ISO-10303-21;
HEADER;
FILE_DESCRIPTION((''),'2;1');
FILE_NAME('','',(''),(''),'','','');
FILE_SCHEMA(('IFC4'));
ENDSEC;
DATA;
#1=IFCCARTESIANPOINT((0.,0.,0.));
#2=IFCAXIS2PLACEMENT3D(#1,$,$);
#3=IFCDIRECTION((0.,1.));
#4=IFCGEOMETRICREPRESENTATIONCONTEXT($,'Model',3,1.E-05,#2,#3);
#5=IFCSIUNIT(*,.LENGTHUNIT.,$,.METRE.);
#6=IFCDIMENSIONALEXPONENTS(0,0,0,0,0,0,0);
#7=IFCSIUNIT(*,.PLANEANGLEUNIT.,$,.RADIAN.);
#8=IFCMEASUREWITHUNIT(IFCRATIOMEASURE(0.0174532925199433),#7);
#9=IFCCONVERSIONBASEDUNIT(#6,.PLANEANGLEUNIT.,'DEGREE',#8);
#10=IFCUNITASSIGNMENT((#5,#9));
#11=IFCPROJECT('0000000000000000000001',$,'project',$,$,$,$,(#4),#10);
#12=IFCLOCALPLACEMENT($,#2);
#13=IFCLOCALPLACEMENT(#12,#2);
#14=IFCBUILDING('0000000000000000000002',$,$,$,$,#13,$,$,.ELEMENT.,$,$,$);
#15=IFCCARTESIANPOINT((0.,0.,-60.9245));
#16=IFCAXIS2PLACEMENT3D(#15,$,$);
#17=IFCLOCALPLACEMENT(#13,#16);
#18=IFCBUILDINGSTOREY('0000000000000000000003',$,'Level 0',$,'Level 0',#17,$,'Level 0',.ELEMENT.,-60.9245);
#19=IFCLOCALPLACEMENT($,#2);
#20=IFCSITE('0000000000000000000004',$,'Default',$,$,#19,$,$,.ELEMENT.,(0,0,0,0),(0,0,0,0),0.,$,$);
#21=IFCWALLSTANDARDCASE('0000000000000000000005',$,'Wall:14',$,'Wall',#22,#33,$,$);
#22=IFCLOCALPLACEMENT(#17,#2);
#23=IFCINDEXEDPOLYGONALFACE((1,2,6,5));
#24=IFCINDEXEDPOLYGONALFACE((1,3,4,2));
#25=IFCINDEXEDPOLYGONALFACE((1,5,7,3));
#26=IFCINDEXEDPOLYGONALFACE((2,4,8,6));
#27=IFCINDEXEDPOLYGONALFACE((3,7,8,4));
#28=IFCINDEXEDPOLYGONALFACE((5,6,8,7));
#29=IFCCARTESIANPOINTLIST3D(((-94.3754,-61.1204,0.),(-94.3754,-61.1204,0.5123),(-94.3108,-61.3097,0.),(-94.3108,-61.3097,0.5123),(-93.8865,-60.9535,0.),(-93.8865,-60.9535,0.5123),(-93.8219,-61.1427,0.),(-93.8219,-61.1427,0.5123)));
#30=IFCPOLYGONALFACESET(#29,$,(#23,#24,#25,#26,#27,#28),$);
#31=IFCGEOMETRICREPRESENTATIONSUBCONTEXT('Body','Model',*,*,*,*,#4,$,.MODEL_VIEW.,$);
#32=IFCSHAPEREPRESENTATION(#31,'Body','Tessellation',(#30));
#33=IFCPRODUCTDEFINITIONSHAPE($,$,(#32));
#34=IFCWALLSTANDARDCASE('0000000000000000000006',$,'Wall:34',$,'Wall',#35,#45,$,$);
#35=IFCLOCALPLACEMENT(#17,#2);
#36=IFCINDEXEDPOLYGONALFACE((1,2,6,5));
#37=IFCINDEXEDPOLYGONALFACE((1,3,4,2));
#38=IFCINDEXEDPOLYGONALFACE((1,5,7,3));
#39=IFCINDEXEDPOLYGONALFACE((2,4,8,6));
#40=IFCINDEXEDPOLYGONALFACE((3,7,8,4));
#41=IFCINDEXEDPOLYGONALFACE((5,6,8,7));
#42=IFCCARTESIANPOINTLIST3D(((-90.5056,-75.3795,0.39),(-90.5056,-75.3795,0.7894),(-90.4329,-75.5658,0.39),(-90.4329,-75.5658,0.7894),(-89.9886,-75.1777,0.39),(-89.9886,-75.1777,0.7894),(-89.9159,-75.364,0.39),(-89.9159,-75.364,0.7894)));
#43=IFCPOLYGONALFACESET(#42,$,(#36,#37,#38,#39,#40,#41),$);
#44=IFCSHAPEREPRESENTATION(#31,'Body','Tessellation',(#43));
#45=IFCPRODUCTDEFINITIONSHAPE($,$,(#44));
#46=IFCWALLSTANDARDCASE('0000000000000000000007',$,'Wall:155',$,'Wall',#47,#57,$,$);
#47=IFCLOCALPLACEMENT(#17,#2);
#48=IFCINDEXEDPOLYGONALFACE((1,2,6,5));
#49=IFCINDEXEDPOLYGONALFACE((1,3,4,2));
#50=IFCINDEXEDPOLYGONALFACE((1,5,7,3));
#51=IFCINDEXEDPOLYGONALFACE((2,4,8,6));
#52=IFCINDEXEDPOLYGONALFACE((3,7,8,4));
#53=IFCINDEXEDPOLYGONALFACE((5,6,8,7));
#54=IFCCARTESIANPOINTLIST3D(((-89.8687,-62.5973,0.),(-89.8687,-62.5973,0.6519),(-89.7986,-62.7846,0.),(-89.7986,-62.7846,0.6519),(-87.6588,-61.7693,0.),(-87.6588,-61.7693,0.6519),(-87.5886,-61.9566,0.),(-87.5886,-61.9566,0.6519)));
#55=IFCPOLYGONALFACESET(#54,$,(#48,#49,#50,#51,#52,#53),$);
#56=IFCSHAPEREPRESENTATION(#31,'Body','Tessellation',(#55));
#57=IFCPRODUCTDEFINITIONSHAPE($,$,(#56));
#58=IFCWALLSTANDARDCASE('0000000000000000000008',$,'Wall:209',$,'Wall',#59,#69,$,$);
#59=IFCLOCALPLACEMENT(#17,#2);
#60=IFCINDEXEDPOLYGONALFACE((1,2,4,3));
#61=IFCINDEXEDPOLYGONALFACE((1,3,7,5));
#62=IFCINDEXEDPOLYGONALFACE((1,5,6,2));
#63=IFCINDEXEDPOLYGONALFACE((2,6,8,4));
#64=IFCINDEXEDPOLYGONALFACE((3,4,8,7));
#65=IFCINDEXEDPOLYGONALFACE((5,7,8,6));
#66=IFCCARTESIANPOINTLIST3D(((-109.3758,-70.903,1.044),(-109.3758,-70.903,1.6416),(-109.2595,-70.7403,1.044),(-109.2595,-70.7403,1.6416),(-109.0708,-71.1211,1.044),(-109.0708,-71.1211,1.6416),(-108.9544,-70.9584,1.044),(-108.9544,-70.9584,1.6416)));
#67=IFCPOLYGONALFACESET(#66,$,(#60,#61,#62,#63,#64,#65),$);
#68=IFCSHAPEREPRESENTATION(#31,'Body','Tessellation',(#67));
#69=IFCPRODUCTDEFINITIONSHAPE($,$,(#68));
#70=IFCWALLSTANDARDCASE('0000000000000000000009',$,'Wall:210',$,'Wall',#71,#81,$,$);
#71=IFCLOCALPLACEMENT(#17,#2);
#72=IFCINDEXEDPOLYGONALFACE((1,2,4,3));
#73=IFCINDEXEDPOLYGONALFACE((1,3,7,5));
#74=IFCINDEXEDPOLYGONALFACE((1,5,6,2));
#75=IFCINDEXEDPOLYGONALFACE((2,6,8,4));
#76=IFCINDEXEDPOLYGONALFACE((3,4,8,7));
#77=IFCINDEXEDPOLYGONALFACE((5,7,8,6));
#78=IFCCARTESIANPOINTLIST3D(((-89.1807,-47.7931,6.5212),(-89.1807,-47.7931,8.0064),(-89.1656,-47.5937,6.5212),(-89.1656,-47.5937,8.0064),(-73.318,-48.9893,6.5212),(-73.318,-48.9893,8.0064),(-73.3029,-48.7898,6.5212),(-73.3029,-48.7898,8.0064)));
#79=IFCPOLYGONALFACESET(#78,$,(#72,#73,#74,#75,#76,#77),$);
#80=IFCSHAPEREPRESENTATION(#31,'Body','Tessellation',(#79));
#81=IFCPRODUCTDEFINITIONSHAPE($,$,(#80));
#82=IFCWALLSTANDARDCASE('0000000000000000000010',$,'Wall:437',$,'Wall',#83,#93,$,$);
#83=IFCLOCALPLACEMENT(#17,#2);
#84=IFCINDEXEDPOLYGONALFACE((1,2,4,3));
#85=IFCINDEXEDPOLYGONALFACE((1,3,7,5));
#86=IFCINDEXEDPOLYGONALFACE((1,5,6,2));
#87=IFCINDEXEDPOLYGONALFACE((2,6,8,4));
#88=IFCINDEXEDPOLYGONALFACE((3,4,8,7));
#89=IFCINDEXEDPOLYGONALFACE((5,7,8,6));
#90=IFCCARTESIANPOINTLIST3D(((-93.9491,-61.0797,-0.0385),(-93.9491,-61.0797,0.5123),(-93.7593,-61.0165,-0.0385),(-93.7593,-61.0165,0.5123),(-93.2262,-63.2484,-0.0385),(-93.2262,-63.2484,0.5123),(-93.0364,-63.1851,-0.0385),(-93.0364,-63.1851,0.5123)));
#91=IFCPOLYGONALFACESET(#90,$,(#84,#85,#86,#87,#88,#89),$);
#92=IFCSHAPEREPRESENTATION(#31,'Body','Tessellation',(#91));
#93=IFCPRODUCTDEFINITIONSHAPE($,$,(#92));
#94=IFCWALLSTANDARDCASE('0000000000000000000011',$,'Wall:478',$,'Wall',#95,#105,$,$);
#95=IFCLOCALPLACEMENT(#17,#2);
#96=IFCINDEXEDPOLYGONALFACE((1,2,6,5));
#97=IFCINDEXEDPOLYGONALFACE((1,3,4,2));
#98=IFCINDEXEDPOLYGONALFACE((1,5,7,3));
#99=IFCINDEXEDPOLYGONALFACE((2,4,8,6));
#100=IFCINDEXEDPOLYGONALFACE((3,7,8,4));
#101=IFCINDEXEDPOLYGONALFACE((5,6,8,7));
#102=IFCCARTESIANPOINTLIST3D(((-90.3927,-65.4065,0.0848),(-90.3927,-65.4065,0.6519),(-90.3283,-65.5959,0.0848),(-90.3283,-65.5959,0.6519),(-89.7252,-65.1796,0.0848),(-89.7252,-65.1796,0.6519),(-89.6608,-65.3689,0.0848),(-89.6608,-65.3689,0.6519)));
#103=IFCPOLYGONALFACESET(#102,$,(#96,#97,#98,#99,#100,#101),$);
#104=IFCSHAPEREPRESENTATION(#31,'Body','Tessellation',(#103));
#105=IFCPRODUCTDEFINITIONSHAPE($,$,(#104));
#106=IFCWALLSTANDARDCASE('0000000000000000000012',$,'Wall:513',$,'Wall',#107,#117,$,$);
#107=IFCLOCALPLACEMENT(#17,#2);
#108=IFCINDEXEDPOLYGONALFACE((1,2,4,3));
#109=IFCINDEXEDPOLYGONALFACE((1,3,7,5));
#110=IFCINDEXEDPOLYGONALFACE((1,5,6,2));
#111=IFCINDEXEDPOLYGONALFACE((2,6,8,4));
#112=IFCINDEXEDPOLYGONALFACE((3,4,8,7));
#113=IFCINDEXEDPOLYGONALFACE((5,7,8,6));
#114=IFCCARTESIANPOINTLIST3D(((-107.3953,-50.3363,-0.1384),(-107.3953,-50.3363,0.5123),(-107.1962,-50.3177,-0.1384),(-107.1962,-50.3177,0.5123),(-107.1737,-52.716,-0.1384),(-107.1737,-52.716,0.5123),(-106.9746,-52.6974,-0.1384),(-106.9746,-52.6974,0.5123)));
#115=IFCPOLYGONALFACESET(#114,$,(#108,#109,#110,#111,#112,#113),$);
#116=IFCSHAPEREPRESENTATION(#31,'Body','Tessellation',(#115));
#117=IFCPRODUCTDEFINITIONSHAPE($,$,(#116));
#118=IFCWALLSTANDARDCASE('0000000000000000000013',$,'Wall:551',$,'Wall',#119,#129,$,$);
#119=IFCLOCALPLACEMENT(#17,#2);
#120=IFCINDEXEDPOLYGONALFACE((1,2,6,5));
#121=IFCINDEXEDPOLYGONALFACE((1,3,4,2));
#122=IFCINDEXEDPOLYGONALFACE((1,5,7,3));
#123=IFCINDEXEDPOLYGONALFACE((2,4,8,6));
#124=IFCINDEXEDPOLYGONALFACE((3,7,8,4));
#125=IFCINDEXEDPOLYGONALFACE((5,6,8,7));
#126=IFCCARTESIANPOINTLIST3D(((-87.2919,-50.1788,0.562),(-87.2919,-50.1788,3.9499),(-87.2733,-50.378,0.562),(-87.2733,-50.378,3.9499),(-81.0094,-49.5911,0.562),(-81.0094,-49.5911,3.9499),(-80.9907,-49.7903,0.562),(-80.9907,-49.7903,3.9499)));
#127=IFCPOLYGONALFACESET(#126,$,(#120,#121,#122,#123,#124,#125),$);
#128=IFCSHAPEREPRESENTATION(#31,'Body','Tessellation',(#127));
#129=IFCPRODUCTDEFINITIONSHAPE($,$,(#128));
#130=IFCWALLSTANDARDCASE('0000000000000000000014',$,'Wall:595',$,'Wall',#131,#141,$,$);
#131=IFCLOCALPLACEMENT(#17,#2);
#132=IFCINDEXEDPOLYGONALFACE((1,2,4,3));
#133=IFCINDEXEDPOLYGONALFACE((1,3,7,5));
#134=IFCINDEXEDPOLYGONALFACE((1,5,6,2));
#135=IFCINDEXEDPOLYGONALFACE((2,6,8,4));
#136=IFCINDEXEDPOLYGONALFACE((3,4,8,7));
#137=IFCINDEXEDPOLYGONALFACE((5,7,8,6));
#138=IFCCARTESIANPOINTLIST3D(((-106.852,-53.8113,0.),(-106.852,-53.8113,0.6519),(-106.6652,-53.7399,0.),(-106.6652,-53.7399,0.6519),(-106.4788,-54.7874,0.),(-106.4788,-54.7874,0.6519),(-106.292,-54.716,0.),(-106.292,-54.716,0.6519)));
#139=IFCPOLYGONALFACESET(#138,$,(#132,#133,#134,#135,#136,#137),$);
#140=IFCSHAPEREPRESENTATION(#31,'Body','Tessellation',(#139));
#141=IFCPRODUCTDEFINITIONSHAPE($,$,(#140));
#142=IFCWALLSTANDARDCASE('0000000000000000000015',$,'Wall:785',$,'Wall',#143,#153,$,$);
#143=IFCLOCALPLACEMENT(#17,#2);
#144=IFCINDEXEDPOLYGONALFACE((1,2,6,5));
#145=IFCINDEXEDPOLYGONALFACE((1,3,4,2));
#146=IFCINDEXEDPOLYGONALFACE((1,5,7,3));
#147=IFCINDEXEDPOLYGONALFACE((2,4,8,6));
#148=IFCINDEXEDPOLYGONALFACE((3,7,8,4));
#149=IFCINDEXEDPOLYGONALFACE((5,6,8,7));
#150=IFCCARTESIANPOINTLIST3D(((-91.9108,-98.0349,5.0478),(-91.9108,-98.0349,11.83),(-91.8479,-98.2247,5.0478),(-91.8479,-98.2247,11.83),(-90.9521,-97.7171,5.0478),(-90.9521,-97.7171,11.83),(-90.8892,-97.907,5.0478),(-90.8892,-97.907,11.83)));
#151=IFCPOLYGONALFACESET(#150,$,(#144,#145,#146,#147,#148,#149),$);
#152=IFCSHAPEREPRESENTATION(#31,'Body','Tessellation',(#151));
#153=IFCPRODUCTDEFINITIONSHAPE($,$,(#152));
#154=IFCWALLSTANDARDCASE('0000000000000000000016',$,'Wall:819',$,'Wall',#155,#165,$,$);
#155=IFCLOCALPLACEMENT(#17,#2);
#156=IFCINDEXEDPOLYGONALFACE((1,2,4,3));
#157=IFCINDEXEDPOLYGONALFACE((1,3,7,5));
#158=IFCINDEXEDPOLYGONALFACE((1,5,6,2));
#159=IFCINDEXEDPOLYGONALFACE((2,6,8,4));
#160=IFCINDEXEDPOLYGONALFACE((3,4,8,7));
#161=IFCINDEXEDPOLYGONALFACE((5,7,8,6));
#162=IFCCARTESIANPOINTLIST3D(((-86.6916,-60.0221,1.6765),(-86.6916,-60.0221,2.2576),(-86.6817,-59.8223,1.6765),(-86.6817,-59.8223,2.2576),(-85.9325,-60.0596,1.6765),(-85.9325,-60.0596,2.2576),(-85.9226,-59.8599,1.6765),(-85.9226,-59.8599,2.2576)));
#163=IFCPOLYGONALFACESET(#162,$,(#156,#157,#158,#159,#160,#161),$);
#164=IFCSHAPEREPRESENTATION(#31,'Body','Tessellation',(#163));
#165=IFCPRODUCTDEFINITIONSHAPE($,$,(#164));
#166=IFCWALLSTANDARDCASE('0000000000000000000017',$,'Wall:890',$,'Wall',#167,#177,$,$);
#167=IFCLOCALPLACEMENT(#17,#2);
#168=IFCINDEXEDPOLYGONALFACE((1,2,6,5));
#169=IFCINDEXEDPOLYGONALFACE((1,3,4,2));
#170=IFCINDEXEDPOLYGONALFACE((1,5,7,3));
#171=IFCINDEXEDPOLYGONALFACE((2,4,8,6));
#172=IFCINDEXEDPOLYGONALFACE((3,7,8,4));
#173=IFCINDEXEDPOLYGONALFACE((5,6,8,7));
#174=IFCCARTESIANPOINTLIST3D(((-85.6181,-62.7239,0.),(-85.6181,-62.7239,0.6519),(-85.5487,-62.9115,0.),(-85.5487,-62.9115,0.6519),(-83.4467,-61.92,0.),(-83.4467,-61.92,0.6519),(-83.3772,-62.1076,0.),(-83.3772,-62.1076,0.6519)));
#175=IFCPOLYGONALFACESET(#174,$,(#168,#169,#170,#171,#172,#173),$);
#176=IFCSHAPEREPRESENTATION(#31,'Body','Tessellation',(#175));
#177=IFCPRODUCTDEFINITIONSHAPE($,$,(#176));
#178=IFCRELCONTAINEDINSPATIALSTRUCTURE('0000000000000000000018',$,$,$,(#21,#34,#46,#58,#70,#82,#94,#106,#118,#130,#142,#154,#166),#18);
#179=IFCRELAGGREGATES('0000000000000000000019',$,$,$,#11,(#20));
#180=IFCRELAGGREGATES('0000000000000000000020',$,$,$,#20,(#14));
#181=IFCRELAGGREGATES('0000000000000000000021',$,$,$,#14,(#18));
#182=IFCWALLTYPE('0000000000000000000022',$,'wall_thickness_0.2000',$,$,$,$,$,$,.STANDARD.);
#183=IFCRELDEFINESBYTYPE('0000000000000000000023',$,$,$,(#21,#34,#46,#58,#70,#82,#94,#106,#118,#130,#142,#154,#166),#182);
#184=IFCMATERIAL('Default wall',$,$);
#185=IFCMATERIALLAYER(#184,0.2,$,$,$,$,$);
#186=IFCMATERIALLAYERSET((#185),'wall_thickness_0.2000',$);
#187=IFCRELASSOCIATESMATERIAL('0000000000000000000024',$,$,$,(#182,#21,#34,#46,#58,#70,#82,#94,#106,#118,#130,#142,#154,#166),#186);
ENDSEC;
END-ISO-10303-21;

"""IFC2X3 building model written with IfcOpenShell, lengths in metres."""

from ifc_helpers import new_model, entity, si_unit, converted_unit, direction, frame, origin, place, context, subcontext, project, spatial, polyline, outline, extrude, material, layer, layer_set, layer_usage, type_object, element, save


model = new_model("IFC2X3")

# Units and contexts
model_context = context("Model", 3, precision=1e-05, world=origin(), true_north=direction((0.0, 1.0)))
body_context = subcontext(model_context, "Body", "Model", "MODEL_VIEW")
ifc_project = project(units=[si_unit("LENGTHUNIT", "METRE"), converted_unit("PLANEANGLEUNIT", "DEGREE", entity("IfcRatioMeasure", 0.0174532925199433), si_unit("PLANEANGLEUNIT", "RADIAN"), dimensions=[0, 0, 0, 0, 0, 0, 0])], contexts=[model_context])

# Site, building, storey
site_placement = place(None, origin())
site = spatial("IfcSite", under=ifc_project, at=site_placement, Name="Default", CompositionType="ELEMENT", RefLatitude=(0, 0, 0, 0), RefLongitude=(0, 0, 0, 0), RefElevation=0.0)
placement_1 = place(None, origin())
building_placement = place(placement_1, origin())
building = spatial("IfcBuilding", under=site, at=building_placement, CompositionType="ELEMENT")
storey_placement = place(building_placement, frame((0.0, 0.0, -60.9245)))
storey = spatial("IfcBuildingStorey", under=building, at=storey_placement, Name="Level 0", ObjectType="Level 0", LongName="Level 0", CompositionType="ELEMENT", Elevation=-60.9245)

# Walls
ifc_material = material(Name="Default wall")
ifc_layer = layer(ifc_material, 0.2)
ifc_layer_set = layer_set([ifc_layer], Name="wall_thickness_0.2000")
ifc_layer_usage = layer_usage(ifc_layer_set, "AXIS2", "POSITIVE", -0.1)
wall_type = type_object("IfcWallType", Name="wall_thickness_0.2000", PredefinedType="STANDARD", material=ifc_layer_set)
wall_1_placement = place(storey_placement, frame((-93.8542, -61.0481, 0.0), z_axis=(0.0, 0.0, 1.0), x_axis=(-0.946342, -0.323168, 0.0)))
element("IfcWallStandardCase", 1, at=wall_1_placement, inside=storey, type_object=wall_type, material=ifc_layer_usage, Name="Wall:14", ObjectType="Wall", context=body_context, shape_type="SweptSolid", body=[
    extrude(outline(polyline([(0.5166, -0.1), (0.5166, 0.1), (0.0, 0.1), (0.0, -0.1), (0.5166, -0.1)])), origin(), (0.0, 0.0, 1.0), 0.5123),
])
placement_2 = place(building_placement, frame((0.0, 0.0, -60.5345)))
wall_2_placement = place(placement_2, frame((-90.4692, -75.4727, 0.0), z_axis=(0.0, 0.0, 1.0), x_axis=(0.931519, 0.363692, 0.0)))
element("IfcWallStandardCase", 2, at=wall_2_placement, inside=storey, type_object=wall_type, material=ifc_layer_usage, Name="Wall:34", ObjectType="Wall", context=body_context, shape_type="SweptSolid", body=[
    extrude(outline(polyline([(0.555, -0.1), (0.555, 0.1), (0.0, 0.1), (0.0, -0.1), (0.555, -0.1)])), origin(), (0.0, 0.0, 1.0), 0.3994),
])
wall_3_placement = place(storey_placement, frame((-89.8337, -62.6909, 0.0), z_axis=(0.0, 0.0, 1.0), x_axis=(0.936428, 0.35086, 0.0)))
element("IfcWallStandardCase", 3, at=wall_3_placement, inside=storey, type_object=wall_type, material=ifc_layer_usage, Name="Wall:155", ObjectType="Wall", context=body_context, shape_type="SweptSolid", body=[
    extrude(outline(polyline([(2.36, -0.1), (2.36, 0.1), (0.0, 0.1), (0.0, -0.1), (2.36, -0.1)])), origin(), (0.0, 0.0, 1.0), 0.6519),
])
placement_3 = place(building_placement, frame((0.0, 0.0, -59.8805)))
wall_4_placement = place(placement_3, frame((-109.0126, -71.0397, 0.0), z_axis=(0.0, 0.0, 1.0), x_axis=(-0.813441, 0.581648, 0.0)))
element("IfcWallStandardCase", 4, at=wall_4_placement, inside=storey, type_object=wall_type, material=ifc_layer_usage, Name="Wall:209", ObjectType="Wall", context=body_context, shape_type="SweptSolid", body=[
    extrude(outline(polyline([(0.375, -0.1), (0.375, 0.1), (0.0, 0.1), (0.0, -0.1), (0.375, -0.1)])), origin(), (0.0, 0.0, 1.0), 0.5976),
])
placement_4 = place(building_placement, frame((0.0, 0.0, -54.4033)))
wall_5_placement = place(placement_4, frame((-89.1732, -47.6934, 0.0), z_axis=(0.0, 0.0, 1.0), x_axis=(0.997169, -0.075191, 0.0)))
element("IfcWallStandardCase", 5, at=wall_5_placement, inside=storey, type_object=wall_type, material=ifc_layer_usage, Name="Wall:210", ObjectType="Wall", context=body_context, shape_type="SweptSolid", body=[
    extrude(outline(polyline([(15.9077, -0.1), (15.9077, 0.1), (0.0, 0.1), (0.0, -0.1), (15.9077, -0.1)])), origin(), (0.0, 0.0, 1.0), 1.4852),
])
placement_5 = place(building_placement, frame((0.0, 0.0, -60.963)))
wall_6_placement = place(placement_5, frame((-93.8542, -61.0481, 0.0), z_axis=(0.0, 0.0, 1.0), x_axis=(0.316232, -0.948682, 0.0)))
element("IfcWallStandardCase", 6, at=wall_6_placement, inside=storey, type_object=wall_type, material=ifc_layer_usage, Name="Wall:437", ObjectType="Wall", context=body_context, shape_type="SweptSolid", body=[
    extrude(outline(polyline([(2.286, -0.1), (2.286, 0.1), (0.0, 0.1), (0.0, -0.1), (2.286, -0.1)])), origin(), (0.0, 0.0, 1.0), 0.5508),
])
placement_6 = place(building_placement, frame((0.0, 0.0, -60.8397)))
wall_7_placement = place(placement_6, frame((-90.3605, -65.5012, 0.0), z_axis=(0.0, 0.0, 1.0), x_axis=(0.94676, 0.321939, 0.0)))
element("IfcWallStandardCase", 7, at=wall_7_placement, inside=storey, type_object=wall_type, material=ifc_layer_usage, Name="Wall:478", ObjectType="Wall", context=body_context, shape_type="SweptSolid", body=[
    extrude(outline(polyline([(0.705, -0.1), (0.705, 0.1), (0.0, 0.1), (0.0, -0.1), (0.705, -0.1)])), origin(), (0.0, 0.0, 1.0), 0.5671),
])
placement_7 = place(building_placement, frame((0.0, 0.0, -61.0629)))
wall_8_placement = place(placement_7, frame((-107.2958, -50.327, 0.0), z_axis=(0.0, 0.0, 1.0), x_axis=(0.092715, -0.995693, 0.0)))
element("IfcWallStandardCase", 8, at=wall_8_placement, inside=storey, type_object=wall_type, material=ifc_layer_usage, Name="Wall:513", ObjectType="Wall", context=body_context, shape_type="SweptSolid", body=[
    extrude(outline(polyline([(2.39, -0.1), (2.39, 0.1), (0.0, 0.1), (0.0, -0.1), (2.39, -0.1)])), origin(), (0.0, 0.0, 1.0), 0.6506),
])
placement_8 = place(building_placement, frame((0.0, 0.0, -60.3625)))
wall_9_placement = place(placement_8, frame((-87.2826, -50.2784, 0.0), z_axis=(0.0, 0.0, 1.0), x_axis=(0.995653, 0.093139, 0.0)))
element("IfcWallStandardCase", 9, at=wall_9_placement, inside=storey, type_object=wall_type, material=ifc_layer_usage, Name="Wall:551", ObjectType="Wall", context=body_context, shape_type="SweptSolid", body=[
    extrude(outline(polyline([(6.31, -0.1), (6.31, 0.1), (0.0, 0.1), (0.0, -0.1), (6.31, -0.1)])), origin(), (0.0, 0.0, 1.0), 3.3879),
])
wall_10_placement = place(storey_placement, frame((-106.7586, -53.7756, 0.0), z_axis=(0.0, 0.0, 1.0), x_axis=(0.357122, -0.934058, 0.0)))
element("IfcWallStandardCase", 10, at=wall_10_placement, inside=storey, type_object=wall_type, material=ifc_layer_usage, Name="Wall:595", ObjectType="Wall", context=body_context, shape_type="SweptSolid", body=[
    extrude(outline(polyline([(1.045, -0.1), (1.045, 0.1), (0.0, 0.1), (0.0, -0.1), (1.045, -0.1)])), origin(), (0.0, 0.0, 1.0), 0.6519),
])
placement_9 = place(building_placement, frame((0.0, 0.0, -55.8767)))
wall_11_placement = place(placement_9, frame((-90.9207, -97.812, 0.0), z_axis=(0.0, 0.0, 1.0), x_axis=(-0.949213, -0.314634, 0.0)))
element("IfcWallStandardCase", 11, at=wall_11_placement, inside=storey, type_object=wall_type, material=ifc_layer_usage, Name="Wall:785", ObjectType="Wall", context=body_context, shape_type="SweptSolid", body=[
    extrude(outline(polyline([(1.01, -0.1), (1.01, 0.1), (0.0, 0.1), (0.0, -0.1), (1.01, -0.1)])), origin(), (0.0, 0.0, 1.0), 6.7822),
])
placement_10 = place(building_placement, frame((0.0, 0.0, -59.248)))
wall_12_placement = place(placement_10, frame((-86.6866, -59.9222, 0.0), z_axis=(0.0, 0.0, 1.0), x_axis=(0.998778, -0.04943, 0.0)))
element("IfcWallStandardCase", 12, at=wall_12_placement, inside=storey, type_object=wall_type, material=ifc_layer_usage, Name="Wall:819", ObjectType="Wall", context=body_context, shape_type="SweptSolid", body=[
    extrude(outline(polyline([(0.76, -0.1), (0.76, 0.1), (0.0, 0.1), (0.0, -0.1), (0.76, -0.1)])), origin(), (0.0, 0.0, 1.0), 0.5811),
])
wall_13_placement = place(storey_placement, frame((-85.5834, -62.8177, 0.0), z_axis=(0.0, 0.0, 1.0), x_axis=(0.937796, 0.347187, 0.0)))
element("IfcWallStandardCase", 13, at=wall_13_placement, inside=storey, type_object=wall_type, material=ifc_layer_usage, Name="Wall:890", ObjectType="Wall", context=body_context, shape_type="SweptSolid", body=[
    extrude(outline(polyline([(2.3155, -0.1), (2.3155, 0.1), (0.0, 0.1), (0.0, -0.1), (2.3155, -0.1)])), origin(), (0.0, 0.0, 1.0), 0.6519),
])

save(model, "model.ifc")
